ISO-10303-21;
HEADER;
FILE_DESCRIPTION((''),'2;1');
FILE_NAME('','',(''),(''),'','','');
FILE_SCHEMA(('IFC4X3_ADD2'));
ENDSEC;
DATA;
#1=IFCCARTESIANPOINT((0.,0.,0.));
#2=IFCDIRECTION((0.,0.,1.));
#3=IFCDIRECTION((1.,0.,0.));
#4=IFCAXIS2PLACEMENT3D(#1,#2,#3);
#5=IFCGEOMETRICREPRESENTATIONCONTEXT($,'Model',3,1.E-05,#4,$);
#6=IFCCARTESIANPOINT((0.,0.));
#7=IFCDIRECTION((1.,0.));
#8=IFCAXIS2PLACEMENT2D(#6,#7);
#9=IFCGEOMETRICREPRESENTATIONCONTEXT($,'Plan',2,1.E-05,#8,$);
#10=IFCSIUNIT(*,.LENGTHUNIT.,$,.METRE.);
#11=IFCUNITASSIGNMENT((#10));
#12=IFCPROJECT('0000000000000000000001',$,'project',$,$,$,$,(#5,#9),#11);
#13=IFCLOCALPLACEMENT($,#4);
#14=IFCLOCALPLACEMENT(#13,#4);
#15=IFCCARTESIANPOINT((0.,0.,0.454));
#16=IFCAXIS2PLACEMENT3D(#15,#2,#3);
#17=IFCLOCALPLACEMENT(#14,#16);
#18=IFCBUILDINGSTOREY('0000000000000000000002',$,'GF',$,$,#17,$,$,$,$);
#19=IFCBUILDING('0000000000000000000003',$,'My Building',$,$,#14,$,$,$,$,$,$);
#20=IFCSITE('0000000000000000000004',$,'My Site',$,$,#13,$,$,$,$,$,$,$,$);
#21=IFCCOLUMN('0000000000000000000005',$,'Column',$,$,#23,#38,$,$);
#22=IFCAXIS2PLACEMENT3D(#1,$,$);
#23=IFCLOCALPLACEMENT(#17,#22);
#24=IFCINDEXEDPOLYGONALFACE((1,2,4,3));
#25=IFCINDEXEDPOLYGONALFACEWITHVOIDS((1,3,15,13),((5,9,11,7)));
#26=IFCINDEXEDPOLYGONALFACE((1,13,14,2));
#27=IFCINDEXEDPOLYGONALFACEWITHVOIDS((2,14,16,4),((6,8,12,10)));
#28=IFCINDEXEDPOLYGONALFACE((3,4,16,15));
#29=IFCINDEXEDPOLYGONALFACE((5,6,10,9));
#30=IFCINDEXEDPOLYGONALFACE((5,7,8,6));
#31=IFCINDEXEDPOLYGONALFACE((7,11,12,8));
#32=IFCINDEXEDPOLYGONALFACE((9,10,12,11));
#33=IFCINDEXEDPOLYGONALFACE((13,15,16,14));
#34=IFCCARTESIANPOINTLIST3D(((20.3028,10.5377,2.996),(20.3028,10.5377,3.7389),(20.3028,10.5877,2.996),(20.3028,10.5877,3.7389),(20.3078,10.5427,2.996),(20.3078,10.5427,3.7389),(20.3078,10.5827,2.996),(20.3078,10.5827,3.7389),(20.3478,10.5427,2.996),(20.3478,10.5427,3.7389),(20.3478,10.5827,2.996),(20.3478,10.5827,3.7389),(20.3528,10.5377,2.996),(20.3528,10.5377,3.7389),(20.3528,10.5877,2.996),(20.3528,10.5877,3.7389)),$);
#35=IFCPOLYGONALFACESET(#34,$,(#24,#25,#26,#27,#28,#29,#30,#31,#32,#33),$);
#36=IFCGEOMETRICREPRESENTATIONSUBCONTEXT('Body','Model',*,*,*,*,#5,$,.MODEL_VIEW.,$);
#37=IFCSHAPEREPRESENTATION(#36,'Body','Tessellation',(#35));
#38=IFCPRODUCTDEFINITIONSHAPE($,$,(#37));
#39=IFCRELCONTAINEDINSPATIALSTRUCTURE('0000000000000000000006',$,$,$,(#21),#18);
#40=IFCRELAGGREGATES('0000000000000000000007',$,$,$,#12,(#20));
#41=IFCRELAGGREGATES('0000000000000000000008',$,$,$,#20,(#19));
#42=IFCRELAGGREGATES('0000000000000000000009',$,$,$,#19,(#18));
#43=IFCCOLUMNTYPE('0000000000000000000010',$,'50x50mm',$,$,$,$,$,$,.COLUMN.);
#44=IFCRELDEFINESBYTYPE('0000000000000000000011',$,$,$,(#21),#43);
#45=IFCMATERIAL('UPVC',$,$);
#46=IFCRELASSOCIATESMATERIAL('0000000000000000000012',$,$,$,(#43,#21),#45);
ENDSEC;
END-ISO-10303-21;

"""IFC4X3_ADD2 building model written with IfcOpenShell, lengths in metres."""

from ifc_helpers import new_model, si_unit, frame, origin_with_axes, origin_2d_with_axis, place, context, subcontext, project, spatial, hollow_rectangle, extrude, material, material_profile, profile_set, profile_usage, type_object, element, save


model = new_model("IFC4X3_ADD2")

# Units and contexts
model_context = context("Model", 3, precision=1e-05, world=origin_with_axes())
plan_context = context("Plan", 2, precision=1e-05, world=origin_2d_with_axis())
body_context = subcontext(model_context, "Body", "Model", "MODEL_VIEW")
ifc_project = project(units=[si_unit("LENGTHUNIT", "METRE")], contexts=[model_context, plan_context])

# Site, building, storey
site_placement = place(None, origin_with_axes())
site = spatial("IfcSite", under=ifc_project, at=site_placement, Name="My Site")
building_placement = place(site_placement, origin_with_axes())
building = spatial("IfcBuilding", under=site, at=building_placement, Name="My Building")
storey_placement = place(building_placement, frame((0.0, 0.0, 0.454), z_axis=(0.0, 0.0, 1.0), x_axis=(1.0, 0.0, 0.0)))
storey = spatial("IfcBuildingStorey", under=building, at=storey_placement, Name="GF")

# Column
ifc_material = material(Name="UPVC")
ifc_material_profile_1 = material_profile(ifc_material, hollow_rectangle(XDim=0.05, YDim=0.05, WallThickness=0.005))
ifc_profile_set_1 = profile_set([ifc_material_profile_1])
column_type_1 = type_object("IfcColumnType", Name="50x50mm", PredefinedType="COLUMN", material=ifc_profile_set_1)
ifc_profile_usage_1 = profile_usage(ifc_profile_set_1)
column_1_placement = place(storey_placement, frame((20.3278, 10.5627, 2.996), z_axis=(0.0, 0.0, 1.0), x_axis=(1.0, 0.0, 0.0)))
element("IfcColumn", 1, at=column_1_placement, inside=storey, type_object=column_type_1, material=ifc_profile_usage_1, Name="Column", context=body_context, shape_type="SweptSolid", body=[
    extrude(hollow_rectangle(XDim=0.05, YDim=0.05, WallThickness=0.005), origin_with_axes(), (0.0, 0.0, 1.0), 0.7429),
])

save(model, "model.ifc")
